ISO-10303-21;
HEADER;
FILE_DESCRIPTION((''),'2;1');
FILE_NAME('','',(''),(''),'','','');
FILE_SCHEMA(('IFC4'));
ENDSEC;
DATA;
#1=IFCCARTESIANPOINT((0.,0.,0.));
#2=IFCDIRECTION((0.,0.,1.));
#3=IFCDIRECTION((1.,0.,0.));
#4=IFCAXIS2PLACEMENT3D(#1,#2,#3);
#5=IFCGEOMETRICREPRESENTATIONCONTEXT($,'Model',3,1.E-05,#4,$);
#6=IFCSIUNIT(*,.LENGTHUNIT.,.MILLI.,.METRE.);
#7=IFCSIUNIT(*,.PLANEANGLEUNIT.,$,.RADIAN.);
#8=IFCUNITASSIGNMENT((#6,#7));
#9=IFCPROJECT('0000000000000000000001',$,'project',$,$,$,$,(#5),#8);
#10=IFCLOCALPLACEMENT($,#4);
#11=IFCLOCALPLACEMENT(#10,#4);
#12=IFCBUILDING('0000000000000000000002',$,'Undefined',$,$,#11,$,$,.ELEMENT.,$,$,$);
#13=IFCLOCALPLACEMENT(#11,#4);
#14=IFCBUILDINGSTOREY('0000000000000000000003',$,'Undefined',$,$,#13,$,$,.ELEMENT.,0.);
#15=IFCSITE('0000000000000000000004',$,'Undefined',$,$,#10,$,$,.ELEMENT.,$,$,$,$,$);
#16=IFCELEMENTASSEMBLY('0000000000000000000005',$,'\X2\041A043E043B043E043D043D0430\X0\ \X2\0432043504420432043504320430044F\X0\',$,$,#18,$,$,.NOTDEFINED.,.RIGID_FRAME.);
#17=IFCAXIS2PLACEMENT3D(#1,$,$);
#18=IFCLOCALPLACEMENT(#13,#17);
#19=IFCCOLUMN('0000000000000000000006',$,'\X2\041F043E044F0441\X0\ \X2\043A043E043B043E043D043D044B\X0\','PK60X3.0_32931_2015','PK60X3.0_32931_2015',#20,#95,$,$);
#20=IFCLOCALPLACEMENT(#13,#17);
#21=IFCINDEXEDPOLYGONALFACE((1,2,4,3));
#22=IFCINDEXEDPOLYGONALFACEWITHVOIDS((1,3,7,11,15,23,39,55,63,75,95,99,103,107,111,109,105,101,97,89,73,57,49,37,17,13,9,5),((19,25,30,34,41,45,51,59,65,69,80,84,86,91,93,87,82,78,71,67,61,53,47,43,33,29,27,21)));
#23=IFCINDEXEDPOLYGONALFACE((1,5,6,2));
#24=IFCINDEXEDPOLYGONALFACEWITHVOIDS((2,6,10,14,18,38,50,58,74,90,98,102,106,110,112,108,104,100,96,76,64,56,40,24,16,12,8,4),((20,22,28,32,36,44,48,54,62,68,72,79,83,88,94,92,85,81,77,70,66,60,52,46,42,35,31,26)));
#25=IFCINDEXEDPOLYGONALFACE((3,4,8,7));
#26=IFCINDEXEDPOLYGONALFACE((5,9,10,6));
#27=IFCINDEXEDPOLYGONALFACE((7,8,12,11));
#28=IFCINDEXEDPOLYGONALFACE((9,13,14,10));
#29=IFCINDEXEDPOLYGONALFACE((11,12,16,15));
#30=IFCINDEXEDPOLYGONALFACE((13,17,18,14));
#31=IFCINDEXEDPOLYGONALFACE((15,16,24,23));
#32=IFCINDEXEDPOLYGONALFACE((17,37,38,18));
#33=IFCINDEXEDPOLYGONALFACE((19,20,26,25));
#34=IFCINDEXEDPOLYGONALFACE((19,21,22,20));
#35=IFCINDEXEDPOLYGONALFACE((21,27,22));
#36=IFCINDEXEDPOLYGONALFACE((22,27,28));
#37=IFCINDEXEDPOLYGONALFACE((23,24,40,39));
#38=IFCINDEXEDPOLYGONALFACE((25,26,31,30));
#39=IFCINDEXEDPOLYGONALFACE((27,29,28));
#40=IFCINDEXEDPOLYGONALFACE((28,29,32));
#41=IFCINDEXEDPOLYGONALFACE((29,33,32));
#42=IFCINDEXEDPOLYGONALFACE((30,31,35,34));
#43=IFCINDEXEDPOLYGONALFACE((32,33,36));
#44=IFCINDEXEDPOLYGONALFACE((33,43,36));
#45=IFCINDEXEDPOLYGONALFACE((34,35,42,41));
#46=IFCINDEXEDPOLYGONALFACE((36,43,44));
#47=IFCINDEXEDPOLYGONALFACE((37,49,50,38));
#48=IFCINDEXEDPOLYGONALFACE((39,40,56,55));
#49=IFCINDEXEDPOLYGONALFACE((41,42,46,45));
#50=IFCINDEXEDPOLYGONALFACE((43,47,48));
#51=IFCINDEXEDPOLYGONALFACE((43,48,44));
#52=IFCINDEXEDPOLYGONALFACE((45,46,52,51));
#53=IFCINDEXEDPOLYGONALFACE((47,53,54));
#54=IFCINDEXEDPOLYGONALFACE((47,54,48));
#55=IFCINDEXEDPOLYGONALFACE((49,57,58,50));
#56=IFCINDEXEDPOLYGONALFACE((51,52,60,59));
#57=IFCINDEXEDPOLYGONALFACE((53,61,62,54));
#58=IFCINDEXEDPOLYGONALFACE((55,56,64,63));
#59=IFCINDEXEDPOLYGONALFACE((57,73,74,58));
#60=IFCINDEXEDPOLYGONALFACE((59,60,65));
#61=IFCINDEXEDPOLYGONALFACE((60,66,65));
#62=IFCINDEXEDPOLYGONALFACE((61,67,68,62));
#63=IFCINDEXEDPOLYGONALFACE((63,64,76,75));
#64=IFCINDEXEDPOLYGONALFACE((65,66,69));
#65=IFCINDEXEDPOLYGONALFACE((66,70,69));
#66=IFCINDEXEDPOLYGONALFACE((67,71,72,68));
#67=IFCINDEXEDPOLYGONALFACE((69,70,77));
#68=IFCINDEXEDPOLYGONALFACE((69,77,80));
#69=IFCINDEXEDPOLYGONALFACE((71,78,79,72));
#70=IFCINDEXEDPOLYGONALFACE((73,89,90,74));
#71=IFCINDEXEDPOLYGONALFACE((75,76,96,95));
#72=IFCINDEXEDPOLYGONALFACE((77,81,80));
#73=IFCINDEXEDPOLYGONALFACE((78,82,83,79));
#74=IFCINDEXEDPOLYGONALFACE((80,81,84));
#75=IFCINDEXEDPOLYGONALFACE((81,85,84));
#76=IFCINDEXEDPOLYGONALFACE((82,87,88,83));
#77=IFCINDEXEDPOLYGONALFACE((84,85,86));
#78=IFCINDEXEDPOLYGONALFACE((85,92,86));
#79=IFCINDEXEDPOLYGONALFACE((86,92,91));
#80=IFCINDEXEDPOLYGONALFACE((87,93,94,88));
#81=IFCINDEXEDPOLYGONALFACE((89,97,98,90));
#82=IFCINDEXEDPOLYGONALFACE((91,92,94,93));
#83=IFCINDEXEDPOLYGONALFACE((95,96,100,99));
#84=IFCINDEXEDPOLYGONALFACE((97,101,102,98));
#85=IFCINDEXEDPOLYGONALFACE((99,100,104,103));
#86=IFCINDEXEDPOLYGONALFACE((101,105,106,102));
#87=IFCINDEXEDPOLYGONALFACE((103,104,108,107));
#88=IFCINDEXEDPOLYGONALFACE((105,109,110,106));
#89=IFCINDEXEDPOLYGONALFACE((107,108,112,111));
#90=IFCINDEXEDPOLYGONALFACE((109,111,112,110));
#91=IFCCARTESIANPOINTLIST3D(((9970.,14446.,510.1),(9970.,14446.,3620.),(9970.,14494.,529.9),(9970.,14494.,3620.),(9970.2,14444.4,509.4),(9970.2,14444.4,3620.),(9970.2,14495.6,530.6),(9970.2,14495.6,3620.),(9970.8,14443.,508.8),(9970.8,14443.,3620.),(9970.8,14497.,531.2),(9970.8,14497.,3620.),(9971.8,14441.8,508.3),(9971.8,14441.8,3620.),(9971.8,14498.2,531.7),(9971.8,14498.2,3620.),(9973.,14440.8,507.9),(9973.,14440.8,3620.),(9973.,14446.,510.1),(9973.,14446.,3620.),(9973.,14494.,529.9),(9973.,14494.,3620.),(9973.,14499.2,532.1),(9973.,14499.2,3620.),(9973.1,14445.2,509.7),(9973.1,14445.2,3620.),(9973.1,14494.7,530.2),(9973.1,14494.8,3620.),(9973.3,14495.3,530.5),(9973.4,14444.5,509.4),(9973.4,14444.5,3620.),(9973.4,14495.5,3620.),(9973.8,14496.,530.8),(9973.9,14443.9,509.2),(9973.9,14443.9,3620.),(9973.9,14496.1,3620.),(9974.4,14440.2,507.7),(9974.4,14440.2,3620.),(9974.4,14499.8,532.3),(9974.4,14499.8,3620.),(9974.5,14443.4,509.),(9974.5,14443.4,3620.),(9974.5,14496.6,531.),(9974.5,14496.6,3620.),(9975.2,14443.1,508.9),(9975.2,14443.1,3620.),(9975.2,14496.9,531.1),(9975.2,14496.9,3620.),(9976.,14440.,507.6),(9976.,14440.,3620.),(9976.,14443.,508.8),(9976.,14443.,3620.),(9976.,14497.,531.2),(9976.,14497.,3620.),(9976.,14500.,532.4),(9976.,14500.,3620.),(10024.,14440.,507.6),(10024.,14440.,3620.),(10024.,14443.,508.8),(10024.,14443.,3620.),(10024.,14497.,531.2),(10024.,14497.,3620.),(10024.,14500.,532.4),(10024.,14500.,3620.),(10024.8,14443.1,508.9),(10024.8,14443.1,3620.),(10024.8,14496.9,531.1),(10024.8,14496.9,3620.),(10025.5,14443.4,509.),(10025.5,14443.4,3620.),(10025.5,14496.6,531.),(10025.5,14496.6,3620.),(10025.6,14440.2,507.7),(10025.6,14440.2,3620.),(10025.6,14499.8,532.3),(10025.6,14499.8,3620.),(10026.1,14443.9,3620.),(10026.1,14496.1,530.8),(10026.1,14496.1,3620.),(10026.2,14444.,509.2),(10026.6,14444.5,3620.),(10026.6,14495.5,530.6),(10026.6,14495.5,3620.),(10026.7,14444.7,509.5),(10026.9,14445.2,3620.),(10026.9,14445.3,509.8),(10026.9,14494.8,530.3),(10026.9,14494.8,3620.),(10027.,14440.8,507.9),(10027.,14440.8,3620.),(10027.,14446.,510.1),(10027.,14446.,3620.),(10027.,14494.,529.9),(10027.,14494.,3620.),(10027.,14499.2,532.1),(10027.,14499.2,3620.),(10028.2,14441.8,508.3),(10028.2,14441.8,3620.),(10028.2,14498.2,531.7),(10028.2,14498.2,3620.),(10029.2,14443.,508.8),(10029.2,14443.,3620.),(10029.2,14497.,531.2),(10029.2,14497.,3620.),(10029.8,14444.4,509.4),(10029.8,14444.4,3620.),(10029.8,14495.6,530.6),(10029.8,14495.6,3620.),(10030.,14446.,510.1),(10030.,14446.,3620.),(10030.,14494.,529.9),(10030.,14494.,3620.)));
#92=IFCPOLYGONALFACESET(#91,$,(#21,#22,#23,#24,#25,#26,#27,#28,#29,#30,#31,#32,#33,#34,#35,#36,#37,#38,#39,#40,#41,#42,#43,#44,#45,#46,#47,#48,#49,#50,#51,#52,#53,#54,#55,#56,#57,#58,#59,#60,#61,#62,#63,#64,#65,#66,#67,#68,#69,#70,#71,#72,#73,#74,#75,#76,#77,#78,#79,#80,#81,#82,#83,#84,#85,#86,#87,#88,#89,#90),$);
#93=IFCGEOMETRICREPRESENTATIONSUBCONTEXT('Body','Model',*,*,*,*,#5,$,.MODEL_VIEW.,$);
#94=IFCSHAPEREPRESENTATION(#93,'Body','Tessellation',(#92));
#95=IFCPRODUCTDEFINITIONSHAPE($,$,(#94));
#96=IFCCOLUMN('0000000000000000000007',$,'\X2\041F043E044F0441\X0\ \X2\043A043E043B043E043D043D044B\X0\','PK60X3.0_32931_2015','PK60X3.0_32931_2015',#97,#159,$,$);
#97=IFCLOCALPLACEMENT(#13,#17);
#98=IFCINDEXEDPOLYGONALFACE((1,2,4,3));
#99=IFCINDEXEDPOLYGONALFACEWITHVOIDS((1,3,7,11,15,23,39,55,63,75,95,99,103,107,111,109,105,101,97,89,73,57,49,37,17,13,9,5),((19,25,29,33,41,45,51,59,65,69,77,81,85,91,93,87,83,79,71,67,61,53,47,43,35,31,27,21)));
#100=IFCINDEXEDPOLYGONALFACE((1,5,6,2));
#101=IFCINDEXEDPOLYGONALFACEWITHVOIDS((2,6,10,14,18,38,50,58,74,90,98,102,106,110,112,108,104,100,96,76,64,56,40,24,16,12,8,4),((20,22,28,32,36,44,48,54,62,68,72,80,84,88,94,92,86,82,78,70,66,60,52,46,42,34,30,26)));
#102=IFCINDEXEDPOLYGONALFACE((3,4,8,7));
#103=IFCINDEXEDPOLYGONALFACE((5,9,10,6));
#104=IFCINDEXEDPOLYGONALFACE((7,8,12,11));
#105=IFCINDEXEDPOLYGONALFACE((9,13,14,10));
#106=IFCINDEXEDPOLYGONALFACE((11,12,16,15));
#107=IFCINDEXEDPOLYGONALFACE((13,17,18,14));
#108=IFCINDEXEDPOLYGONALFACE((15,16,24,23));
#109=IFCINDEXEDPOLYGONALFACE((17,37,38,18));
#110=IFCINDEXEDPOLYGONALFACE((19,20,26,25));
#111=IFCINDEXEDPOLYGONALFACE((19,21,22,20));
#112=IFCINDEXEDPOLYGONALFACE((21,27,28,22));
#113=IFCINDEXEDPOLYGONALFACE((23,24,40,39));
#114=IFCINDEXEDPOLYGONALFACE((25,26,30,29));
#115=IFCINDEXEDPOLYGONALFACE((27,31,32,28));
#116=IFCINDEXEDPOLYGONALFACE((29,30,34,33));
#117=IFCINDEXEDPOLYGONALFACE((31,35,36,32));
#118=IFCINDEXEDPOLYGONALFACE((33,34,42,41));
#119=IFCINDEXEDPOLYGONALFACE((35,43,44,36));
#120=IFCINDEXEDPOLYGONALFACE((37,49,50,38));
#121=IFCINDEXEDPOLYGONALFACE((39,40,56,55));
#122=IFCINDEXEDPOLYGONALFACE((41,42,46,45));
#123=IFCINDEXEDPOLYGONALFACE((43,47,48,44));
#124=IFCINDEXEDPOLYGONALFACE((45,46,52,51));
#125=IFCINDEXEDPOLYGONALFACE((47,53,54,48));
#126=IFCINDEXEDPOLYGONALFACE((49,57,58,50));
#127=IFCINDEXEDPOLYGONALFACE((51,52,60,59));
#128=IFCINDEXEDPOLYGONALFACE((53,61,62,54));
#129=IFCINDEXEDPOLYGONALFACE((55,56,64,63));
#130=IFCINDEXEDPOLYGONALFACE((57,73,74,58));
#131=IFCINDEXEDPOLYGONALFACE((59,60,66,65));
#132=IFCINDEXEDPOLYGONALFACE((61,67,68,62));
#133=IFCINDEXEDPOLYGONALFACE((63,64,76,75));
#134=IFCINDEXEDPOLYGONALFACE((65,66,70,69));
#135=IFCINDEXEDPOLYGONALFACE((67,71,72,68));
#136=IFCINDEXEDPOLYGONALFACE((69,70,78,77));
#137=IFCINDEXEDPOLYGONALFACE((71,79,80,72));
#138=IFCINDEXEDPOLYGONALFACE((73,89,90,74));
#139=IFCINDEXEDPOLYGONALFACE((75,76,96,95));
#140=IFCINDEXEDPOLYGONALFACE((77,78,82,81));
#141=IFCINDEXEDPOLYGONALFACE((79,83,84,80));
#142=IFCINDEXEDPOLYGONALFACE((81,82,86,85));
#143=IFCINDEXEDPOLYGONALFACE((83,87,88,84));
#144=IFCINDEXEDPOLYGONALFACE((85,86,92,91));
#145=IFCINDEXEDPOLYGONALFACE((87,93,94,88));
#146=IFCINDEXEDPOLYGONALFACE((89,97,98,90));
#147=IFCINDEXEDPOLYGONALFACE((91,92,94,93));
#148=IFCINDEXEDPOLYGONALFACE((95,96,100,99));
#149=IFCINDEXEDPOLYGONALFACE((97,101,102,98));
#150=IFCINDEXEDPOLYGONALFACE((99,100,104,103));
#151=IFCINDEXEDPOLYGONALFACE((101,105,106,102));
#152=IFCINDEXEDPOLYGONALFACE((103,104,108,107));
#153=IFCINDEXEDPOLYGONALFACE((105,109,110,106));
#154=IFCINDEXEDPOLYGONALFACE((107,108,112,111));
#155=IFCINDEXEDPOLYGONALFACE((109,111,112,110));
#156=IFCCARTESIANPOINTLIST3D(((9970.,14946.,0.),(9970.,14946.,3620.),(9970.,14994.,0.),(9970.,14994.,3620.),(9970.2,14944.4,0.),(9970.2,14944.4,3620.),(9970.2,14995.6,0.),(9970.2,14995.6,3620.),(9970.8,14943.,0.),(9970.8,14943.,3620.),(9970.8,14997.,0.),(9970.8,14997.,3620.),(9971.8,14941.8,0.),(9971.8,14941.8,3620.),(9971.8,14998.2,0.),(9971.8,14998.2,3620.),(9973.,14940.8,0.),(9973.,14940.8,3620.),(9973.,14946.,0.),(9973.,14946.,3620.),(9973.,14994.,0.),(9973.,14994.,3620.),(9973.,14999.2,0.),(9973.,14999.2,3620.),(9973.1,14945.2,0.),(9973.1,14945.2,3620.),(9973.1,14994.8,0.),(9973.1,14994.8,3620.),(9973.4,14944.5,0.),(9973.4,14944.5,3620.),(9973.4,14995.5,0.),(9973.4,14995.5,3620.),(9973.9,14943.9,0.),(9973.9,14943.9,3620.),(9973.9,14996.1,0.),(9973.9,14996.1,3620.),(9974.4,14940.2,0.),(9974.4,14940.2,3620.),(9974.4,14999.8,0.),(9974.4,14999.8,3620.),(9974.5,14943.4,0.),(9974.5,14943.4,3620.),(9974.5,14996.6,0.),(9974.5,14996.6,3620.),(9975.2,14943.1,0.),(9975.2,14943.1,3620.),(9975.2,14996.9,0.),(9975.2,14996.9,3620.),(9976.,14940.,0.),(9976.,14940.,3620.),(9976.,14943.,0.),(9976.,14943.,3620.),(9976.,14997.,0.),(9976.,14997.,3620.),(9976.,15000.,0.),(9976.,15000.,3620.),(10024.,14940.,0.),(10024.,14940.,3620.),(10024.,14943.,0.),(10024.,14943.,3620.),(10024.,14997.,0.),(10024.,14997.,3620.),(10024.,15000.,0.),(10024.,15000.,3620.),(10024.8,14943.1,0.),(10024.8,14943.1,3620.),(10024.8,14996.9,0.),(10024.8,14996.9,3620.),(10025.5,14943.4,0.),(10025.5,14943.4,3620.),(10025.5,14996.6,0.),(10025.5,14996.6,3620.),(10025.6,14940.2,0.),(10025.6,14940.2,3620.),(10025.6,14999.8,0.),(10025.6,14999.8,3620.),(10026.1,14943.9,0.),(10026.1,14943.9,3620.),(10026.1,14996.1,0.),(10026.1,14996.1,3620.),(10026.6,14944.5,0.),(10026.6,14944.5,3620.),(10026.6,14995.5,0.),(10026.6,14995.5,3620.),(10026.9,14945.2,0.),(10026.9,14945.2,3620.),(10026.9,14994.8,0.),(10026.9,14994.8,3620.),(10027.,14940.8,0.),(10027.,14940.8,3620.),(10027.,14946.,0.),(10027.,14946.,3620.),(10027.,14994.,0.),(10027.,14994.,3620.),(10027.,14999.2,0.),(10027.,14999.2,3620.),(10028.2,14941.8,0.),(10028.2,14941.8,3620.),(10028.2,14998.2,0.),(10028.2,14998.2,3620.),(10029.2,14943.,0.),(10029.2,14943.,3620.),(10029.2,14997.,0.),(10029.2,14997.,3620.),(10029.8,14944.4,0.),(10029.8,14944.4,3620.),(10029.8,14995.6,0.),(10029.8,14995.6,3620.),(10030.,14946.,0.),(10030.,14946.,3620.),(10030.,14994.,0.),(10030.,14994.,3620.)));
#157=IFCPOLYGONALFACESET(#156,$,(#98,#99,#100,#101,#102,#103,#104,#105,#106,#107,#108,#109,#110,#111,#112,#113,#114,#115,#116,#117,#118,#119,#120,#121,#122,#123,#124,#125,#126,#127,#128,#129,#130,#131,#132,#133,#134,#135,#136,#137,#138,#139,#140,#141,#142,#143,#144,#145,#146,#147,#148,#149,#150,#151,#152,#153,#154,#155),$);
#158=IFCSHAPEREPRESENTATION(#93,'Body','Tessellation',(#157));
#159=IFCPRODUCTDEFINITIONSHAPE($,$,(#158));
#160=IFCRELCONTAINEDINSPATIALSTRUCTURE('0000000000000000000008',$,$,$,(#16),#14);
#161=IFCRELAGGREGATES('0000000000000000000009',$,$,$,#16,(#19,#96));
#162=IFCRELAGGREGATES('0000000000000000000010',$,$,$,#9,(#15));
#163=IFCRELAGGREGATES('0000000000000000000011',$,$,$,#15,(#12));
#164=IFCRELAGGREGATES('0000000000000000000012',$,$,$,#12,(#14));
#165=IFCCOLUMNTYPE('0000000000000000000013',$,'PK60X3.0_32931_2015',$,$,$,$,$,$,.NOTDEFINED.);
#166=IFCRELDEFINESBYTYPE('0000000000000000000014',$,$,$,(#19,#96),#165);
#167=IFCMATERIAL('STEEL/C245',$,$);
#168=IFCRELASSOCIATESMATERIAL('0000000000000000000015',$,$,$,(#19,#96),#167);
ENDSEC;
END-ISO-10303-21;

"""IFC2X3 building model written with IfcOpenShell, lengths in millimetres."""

from ifc_helpers import new_model, si_unit, frame, origin_with_axes, origin_2d_with_axis, place, context, subcontext, project, spatial, hollow_rectangle, extrude, clip, halfspace, material, type_object, element, aggregate, save


model = new_model("IFC2X3")

# Units and contexts
model_context = context("Model", 3, precision=1e-05, world=origin_with_axes())
body_context = subcontext(model_context, "Body", "Model", "MODEL_VIEW")
ifc_project = project(units=[si_unit("LENGTHUNIT", "METRE", prefix="MILLI"), si_unit("PLANEANGLEUNIT", "RADIAN")], contexts=[model_context])

# Site, building, storey
site_placement = place(None, origin_with_axes())
site = spatial("IfcSite", under=ifc_project, at=site_placement, Name="Undefined", CompositionType="ELEMENT")
building_placement = place(site_placement, origin_with_axes())
building = spatial("IfcBuilding", under=site, at=building_placement, Name="Undefined", CompositionType="ELEMENT")
storey_placement = place(building_placement, origin_with_axes())
storey = spatial("IfcBuildingStorey", under=building, at=storey_placement, Name="Undefined", CompositionType="ELEMENT", Elevation=0.0)

# Element assembly, columns
assembly_1_placement = place(storey_placement, origin_with_axes())
assembly_1 = element("IfcElementAssembly", 1, at=assembly_1_placement, inside=storey, Name="Колонна ветвевая", AssemblyPlace="NOTDEFINED", PredefinedType="RIGID_FRAME")
ifc_material_1 = material(Name="STEEL/C245")
column_type = type_object("IfcColumnType", Name="PK60X3.0_32931_2015", PredefinedType="NOTDEFINED")
column_1_placement = place(assembly_1_placement, frame((10000.0, 14470.0, 0.0), z_axis=(0.0, 0.0, 1.0), x_axis=(-1.0, 0.0, 0.0)))
column_1 = element("IfcColumn", 2, at=column_1_placement, type_object=column_type, material=ifc_material_1, Name="Пояс колонны", Description="PK60X3.0_32931_2015", ObjectType="PK60X3.0_32931_2015", context=body_context, shape_type="Clipping", body=[
    clip(extrude(hollow_rectangle(XDim=60.0, YDim=60.0, WallThickness=3.0, InnerFilletRadius=3.0, OuterFilletRadius=6.0, at=origin_2d_with_axis()), frame((0.0, 0.0, 3620.0), z_axis=(0.0, 0.0, -1.0), x_axis=(0.0, 1.0, 0.0)), (0.0, 0.0, 1.0), 3112.6), halfspace(frame((0.0, -30.0, 532.4), z_axis=(0.0, 0.382683, 0.92388), x_axis=(-1.0, 0.0, 0.0)), True)),
])
column_2_placement = place(assembly_1_placement, frame((10000.0, 14970.0, 0.0), z_axis=(0.0, 0.0, 1.0), x_axis=(-1.0, 0.0, 0.0)))
column_2 = element("IfcColumn", 3, at=column_2_placement, type_object=column_type, material=ifc_material_1, Name="Пояс колонны", Description="PK60X3.0_32931_2015", ObjectType="PK60X3.0_32931_2015", context=body_context, shape_type="SweptSolid", body=[
    extrude(hollow_rectangle(XDim=60.0, YDim=60.0, WallThickness=3.0, InnerFilletRadius=3.0, OuterFilletRadius=6.0, at=origin_2d_with_axis()), frame((0.0, 0.0, 3620.0), z_axis=(0.0, 0.0, -1.0), x_axis=(0.0, 1.0, 0.0)), (0.0, 0.0, 1.0), 3620.0),
])

aggregate(assembly_1, [column_1, column_2])

save(model, "model.ifc")
